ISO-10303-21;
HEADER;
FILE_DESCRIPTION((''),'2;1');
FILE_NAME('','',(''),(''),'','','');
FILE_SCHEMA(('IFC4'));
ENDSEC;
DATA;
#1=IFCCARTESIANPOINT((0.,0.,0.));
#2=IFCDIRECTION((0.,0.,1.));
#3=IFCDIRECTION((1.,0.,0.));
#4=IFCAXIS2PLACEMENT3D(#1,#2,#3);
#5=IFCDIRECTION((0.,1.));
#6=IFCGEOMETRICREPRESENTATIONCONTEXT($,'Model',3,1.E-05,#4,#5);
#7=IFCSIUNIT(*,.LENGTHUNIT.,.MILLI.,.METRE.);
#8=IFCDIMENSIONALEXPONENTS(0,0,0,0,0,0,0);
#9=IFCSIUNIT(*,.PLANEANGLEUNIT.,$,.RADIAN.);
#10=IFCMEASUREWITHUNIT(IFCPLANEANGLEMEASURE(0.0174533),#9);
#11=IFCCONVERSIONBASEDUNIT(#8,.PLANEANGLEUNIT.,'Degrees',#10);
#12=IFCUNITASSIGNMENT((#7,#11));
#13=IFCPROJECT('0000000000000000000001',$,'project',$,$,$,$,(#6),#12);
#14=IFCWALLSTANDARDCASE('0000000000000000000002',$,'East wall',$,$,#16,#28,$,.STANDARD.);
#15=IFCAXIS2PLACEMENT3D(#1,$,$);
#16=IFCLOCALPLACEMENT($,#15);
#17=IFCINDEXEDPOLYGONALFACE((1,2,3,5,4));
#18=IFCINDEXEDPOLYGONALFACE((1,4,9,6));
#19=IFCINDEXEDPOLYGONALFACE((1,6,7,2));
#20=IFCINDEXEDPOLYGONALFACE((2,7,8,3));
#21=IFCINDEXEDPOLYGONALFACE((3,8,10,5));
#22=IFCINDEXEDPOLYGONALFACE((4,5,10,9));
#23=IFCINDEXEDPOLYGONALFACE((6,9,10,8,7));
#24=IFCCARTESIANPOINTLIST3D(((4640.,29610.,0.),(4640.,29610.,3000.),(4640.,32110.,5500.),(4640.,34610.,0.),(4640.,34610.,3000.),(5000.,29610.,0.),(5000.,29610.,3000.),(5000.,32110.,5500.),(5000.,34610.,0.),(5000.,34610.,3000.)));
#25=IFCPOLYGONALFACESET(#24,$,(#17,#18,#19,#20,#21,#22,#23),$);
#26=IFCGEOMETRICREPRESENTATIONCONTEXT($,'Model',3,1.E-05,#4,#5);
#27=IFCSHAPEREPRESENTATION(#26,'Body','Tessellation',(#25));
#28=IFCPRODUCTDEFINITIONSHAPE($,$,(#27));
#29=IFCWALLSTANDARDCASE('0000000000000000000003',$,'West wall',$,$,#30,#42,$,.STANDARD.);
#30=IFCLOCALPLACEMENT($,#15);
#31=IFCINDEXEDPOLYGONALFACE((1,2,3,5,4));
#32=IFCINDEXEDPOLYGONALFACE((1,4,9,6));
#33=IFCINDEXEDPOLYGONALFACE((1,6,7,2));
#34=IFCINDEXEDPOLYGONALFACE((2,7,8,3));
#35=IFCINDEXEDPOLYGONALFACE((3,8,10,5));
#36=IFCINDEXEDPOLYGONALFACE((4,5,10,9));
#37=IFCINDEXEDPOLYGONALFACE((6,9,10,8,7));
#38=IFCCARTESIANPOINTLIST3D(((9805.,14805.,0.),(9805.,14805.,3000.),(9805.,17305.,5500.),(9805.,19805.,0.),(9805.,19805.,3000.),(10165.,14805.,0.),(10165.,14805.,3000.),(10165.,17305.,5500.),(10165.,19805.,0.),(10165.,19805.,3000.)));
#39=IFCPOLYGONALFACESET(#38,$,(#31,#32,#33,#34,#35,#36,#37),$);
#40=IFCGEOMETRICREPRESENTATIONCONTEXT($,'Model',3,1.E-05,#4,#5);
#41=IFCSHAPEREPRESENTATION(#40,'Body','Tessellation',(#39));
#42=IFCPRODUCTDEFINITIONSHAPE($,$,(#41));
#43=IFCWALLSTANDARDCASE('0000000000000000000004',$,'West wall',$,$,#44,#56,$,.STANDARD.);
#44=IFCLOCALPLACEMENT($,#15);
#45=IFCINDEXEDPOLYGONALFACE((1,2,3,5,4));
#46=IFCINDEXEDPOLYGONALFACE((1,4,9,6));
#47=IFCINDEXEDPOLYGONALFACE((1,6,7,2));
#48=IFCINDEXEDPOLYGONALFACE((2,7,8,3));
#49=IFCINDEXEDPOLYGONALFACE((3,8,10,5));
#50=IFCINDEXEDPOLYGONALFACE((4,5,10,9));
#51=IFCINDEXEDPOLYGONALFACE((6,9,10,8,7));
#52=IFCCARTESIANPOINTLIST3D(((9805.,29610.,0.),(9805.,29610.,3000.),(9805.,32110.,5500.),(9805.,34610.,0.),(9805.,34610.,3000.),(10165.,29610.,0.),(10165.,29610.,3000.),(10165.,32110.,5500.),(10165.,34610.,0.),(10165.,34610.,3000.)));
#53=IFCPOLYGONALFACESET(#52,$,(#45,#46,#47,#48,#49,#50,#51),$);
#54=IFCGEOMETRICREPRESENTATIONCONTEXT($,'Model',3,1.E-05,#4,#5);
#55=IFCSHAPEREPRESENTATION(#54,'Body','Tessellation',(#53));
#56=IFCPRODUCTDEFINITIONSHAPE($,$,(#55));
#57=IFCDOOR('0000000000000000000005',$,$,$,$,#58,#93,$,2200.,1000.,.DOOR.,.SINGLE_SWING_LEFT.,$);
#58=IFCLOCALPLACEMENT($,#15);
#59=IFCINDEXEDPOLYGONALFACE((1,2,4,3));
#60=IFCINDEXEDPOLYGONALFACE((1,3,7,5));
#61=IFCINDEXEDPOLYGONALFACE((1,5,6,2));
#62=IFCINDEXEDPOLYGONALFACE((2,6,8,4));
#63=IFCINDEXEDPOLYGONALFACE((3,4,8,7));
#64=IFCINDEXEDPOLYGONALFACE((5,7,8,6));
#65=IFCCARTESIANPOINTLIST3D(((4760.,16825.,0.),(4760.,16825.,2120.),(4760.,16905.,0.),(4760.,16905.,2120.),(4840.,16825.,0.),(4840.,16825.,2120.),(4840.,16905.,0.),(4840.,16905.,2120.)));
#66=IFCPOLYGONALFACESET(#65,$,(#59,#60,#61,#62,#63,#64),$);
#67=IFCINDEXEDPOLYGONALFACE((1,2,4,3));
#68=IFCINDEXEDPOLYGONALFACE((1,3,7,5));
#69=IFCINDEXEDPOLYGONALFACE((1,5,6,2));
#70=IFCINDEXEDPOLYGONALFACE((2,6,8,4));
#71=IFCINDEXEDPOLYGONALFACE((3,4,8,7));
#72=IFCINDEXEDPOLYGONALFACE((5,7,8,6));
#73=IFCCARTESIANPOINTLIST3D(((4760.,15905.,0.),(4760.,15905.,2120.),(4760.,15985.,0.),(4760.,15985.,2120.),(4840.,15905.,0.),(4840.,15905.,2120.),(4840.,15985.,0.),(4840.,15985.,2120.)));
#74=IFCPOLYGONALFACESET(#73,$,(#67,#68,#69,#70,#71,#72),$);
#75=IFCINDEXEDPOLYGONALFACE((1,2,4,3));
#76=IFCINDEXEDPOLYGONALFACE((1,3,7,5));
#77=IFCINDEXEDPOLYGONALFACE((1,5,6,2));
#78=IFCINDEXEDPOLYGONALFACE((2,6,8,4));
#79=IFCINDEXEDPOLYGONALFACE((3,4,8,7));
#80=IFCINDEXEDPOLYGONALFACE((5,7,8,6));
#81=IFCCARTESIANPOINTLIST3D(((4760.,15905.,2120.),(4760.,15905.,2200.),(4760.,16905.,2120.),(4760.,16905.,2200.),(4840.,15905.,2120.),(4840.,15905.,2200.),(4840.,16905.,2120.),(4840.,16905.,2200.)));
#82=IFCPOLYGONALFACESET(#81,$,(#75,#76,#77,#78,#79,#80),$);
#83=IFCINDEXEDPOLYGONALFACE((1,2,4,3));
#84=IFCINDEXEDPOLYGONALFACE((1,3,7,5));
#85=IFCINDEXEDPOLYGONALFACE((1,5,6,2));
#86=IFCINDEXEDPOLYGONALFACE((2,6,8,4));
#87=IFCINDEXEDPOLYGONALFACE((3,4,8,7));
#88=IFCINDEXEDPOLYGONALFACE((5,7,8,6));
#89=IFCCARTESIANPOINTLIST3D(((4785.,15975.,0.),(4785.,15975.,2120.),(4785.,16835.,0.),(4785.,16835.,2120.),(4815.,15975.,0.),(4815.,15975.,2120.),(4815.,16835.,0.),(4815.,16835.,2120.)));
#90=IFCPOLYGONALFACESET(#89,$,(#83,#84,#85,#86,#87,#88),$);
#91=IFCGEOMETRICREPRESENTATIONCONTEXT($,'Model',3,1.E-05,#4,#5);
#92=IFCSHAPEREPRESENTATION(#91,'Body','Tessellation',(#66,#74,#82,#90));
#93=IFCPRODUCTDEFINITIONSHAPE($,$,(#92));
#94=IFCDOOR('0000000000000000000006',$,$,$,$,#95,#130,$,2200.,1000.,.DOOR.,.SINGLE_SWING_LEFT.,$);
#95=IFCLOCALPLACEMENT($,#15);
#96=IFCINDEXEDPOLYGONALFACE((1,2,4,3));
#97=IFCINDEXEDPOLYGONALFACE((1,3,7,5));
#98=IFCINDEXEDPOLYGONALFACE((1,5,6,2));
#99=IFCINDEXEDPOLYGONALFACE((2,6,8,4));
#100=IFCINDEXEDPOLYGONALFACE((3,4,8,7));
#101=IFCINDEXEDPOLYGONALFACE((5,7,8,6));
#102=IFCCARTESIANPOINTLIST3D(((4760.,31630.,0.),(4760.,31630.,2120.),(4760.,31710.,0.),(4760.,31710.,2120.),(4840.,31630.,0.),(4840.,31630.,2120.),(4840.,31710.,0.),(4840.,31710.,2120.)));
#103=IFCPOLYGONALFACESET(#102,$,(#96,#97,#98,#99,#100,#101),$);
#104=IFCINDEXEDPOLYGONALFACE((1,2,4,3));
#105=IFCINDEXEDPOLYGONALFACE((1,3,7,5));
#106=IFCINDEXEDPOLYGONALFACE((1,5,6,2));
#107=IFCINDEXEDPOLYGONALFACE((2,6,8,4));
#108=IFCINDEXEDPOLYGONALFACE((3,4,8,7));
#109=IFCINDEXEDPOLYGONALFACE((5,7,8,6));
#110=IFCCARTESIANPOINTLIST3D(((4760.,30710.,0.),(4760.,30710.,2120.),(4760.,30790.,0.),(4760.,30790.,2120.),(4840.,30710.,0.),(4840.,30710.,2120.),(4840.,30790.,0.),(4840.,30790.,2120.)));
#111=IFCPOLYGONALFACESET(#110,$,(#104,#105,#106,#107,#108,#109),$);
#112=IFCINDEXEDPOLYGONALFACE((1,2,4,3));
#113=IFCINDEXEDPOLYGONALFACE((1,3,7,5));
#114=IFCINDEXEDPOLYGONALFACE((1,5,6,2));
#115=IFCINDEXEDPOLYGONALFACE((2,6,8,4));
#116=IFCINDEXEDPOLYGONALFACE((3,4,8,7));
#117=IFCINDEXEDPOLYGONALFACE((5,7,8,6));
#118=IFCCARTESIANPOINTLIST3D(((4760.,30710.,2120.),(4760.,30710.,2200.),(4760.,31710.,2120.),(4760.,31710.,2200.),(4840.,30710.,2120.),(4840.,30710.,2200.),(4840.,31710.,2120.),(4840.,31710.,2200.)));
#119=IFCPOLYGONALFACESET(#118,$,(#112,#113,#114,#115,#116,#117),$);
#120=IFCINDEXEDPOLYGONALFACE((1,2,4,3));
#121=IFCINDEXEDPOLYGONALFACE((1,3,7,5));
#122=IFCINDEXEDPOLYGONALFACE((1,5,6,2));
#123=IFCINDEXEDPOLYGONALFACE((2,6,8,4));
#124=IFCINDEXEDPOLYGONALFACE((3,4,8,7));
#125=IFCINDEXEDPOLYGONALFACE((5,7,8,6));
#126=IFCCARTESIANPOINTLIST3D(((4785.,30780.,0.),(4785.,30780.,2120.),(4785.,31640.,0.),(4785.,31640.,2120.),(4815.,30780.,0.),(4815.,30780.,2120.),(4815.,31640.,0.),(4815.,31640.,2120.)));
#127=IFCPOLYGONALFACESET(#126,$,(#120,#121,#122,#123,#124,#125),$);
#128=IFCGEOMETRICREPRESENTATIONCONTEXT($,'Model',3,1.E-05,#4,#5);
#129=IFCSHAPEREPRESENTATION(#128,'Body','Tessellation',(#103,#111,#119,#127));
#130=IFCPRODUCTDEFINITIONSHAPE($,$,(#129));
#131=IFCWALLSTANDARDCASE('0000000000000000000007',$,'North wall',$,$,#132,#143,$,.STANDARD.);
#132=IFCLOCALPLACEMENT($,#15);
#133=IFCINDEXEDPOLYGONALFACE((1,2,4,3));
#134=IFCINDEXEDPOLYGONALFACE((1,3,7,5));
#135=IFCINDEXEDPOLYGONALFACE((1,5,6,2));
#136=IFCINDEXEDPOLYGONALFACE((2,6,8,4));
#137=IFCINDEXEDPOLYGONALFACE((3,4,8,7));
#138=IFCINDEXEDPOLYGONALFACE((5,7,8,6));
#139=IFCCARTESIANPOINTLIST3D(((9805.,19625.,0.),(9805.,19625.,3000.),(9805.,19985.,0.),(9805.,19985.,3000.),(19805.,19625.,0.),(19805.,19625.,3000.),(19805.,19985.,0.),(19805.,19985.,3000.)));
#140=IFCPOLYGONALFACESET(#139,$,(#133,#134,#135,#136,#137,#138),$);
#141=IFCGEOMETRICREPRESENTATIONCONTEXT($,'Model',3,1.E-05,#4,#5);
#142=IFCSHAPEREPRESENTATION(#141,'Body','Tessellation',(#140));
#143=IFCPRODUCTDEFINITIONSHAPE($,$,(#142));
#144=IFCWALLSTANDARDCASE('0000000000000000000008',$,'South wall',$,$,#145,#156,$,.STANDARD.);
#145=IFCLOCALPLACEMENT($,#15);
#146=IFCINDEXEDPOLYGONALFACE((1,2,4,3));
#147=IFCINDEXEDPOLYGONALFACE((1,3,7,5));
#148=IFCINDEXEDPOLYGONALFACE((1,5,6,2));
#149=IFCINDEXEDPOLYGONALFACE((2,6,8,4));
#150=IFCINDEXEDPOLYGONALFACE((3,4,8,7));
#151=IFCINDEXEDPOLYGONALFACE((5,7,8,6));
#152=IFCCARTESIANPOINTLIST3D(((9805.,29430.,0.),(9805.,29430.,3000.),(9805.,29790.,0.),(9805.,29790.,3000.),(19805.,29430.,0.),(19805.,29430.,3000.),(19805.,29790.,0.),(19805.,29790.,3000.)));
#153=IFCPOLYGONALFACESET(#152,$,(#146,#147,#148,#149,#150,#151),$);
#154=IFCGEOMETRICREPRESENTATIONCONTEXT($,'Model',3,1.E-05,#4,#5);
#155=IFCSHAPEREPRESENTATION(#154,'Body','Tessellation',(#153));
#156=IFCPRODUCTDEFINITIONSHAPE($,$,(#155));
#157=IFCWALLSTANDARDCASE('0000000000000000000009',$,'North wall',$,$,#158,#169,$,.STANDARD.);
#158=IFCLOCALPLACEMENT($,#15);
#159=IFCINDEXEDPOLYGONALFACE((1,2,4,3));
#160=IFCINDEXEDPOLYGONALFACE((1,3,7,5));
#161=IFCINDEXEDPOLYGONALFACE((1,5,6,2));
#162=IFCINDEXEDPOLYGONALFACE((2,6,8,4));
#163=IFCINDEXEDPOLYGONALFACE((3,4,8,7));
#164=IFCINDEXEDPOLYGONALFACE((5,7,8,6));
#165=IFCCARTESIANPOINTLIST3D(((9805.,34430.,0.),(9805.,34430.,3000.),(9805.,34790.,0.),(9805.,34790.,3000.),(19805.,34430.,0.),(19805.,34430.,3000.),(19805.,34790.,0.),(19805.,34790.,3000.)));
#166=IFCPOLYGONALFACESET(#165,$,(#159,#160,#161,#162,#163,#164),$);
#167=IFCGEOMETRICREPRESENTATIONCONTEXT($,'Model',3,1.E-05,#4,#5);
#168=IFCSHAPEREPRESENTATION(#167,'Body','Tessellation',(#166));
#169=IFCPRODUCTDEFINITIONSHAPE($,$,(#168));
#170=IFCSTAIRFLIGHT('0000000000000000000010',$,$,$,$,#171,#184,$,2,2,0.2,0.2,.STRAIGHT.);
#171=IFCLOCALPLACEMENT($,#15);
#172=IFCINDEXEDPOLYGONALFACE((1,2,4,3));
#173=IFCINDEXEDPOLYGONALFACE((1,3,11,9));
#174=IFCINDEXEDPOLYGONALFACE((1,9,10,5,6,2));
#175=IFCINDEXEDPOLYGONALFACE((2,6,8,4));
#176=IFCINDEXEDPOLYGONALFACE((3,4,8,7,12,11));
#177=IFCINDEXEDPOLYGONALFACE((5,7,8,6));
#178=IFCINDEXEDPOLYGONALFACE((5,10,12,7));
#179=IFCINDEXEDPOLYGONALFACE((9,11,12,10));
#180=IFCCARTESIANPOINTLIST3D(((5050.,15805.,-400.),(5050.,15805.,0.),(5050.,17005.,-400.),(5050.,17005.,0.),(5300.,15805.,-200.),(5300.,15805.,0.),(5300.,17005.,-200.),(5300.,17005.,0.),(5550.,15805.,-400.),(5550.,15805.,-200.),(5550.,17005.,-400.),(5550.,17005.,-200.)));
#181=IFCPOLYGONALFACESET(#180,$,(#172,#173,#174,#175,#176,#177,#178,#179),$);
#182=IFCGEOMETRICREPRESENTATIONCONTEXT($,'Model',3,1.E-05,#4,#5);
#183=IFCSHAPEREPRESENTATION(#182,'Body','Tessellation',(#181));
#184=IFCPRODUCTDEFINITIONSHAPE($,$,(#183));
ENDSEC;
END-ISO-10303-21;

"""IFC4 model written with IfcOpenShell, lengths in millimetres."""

from ifc_helpers import new_model, entity, si_unit, converted_unit, direction, frame, origin_with_axes, place, context, project, polyline, outline, extrude, clip, halfspace, source, transform, mapped, element, save


model = new_model("IFC4")

# Units and contexts
model_context_1 = context("Model", 3, precision=1e-05, world=origin_with_axes(), true_north=direction((0.0, 1.0)))
model_context_2 = context("Model", 3, precision=1e-05, world=origin_with_axes(), true_north=direction((0.0, 1.0)))
model_context_3 = context("Model", 3, precision=1e-05, world=origin_with_axes(), true_north=direction((0.0, 1.0)))
model_context_4 = context("Model", 3, precision=1e-05, world=origin_with_axes(), true_north=direction((0.0, 1.0)))
model_context_5 = context("Model", 3, precision=1e-05, world=origin_with_axes(), true_north=direction((0.0, 1.0)))
model_context_6 = context("Model", 3, precision=1e-05, world=origin_with_axes(), true_north=direction((0.0, 1.0)))
model_context_7 = context("Model", 3, precision=1e-05, world=origin_with_axes(), true_north=direction((0.0, 1.0)))
model_context_8 = context("Model", 3, precision=1e-05, world=origin_with_axes(), true_north=direction((0.0, 1.0)))
model_context_9 = context("Model", 3, precision=1e-05, world=origin_with_axes(), true_north=direction((0.0, 1.0)))
model_context_10 = context("Model", 3, precision=1e-05, world=origin_with_axes(), true_north=direction((0.0, 1.0)))
ifc_project = project(units=[si_unit("LENGTHUNIT", "METRE", prefix="MILLI"), converted_unit("PLANEANGLEUNIT", "Degrees", entity("IfcPlaneAngleMeasure", 0.0174533), si_unit("PLANEANGLEUNIT", "RADIAN"), dimensions=[0, 0, 0, 0, 0, 0, 0])], contexts=[model_context_1])

# Shared definitions
placement_1 = place(None, frame((14805.0, 14805.0, 0.0)))
placement_2 = place(None, frame((14805.0, 29610.0, 0.0)))

# Shared definitions
placement_3 = place(None, frame((0.0, 29610.0, 0.0)))

# Walls
placement_4 = place(None, frame((0.0, 14805.0, 0.0)))
shared_shape_1 = source(origin_with_axes(), model_context_5, "Body", "Clipping", [
    clip(clip(extrude(outline(polyline([(-2500.0, -180.0), (2500.0, -180.0), (2500.0, 180.0), (-2500.0, 180.0), (-2500.0, -180.0), (-2500.0, -180.0)])), origin_with_axes(), (0.0, 0.0, 1.0), 6000.0), halfspace(frame((-2500.0, 0.0, 3000.0), z_axis=(-1.0, 0.0, 1.0), x_axis=(1.0, 0.0, 0.0)), False)), halfspace(frame((2500.0, 0.0, 3000.0), z_axis=(1.0, 0.0, 1.0), x_axis=(1.0, 0.0, 0.0)), False)),
])
wall_1_placement = place(placement_3, frame((4820.0, 2500.0, 0.0), z_axis=(0.0, 0.0, 1.0), x_axis=(0.0, 1.0, 0.0)))
element("IfcWallStandardCase", 1, at=wall_1_placement, Name="East wall", PredefinedType="STANDARD", context=model_context_5, shape_type="MappedRepresentation", body=[
    mapped(shared_shape_1, transform((0.0, 0.0, 0.0))),
])
shared_shape_2 = source(origin_with_axes(), model_context_7, "Body", "Clipping", [
    clip(clip(extrude(outline(polyline([(-2500.0, -180.0), (2500.0, -180.0), (2500.0, 180.0), (-2500.0, 180.0), (-2500.0, -180.0), (-2500.0, -180.0)])), origin_with_axes(), (0.0, 0.0, 1.0), 6000.0), halfspace(frame((-2500.0, 0.0, 3000.0), z_axis=(-1.0, 0.0, 1.0), x_axis=(1.0, 0.0, 0.0)), False)), halfspace(frame((2500.0, 0.0, 3000.0), z_axis=(1.0, 0.0, 1.0), x_axis=(1.0, 0.0, 0.0)), False)),
])
wall_2_placement = place(placement_1, frame((-4820.0, 2500.0, 0.0), z_axis=(0.0, 0.0, 1.0), x_axis=(0.0, -1.0, 0.0)))
element("IfcWallStandardCase", 2, at=wall_2_placement, Name="West wall", PredefinedType="STANDARD", context=model_context_7, shape_type="MappedRepresentation", body=[
    mapped(shared_shape_2, transform((0.0, 0.0, 0.0))),
])
shared_shape_3 = source(origin_with_axes(), model_context_10, "Body", "Clipping", [
    clip(clip(extrude(outline(polyline([(-2500.0, -180.0), (2500.0, -180.0), (2500.0, 180.0), (-2500.0, 180.0), (-2500.0, -180.0), (-2500.0, -180.0)])), origin_with_axes(), (0.0, 0.0, 1.0), 6000.0), halfspace(frame((-2500.0, 0.0, 3000.0), z_axis=(-1.0, 0.0, 1.0), x_axis=(1.0, 0.0, 0.0)), False)), halfspace(frame((2500.0, 0.0, 3000.0), z_axis=(1.0, 0.0, 1.0), x_axis=(1.0, 0.0, 0.0)), False)),
])
wall_3_placement = place(placement_2, frame((-4820.0, 2500.0, 0.0), z_axis=(0.0, 0.0, 1.0), x_axis=(0.0, -1.0, 0.0)))
element("IfcWallStandardCase", 3, at=wall_3_placement, Name="West wall", PredefinedType="STANDARD", context=model_context_10, shape_type="MappedRepresentation", body=[
    mapped(shared_shape_3, transform((0.0, 0.0, 0.0))),
])

# Doors
door_1_placement = place(placement_4, frame((4800.0, 1600.0, 0.0), z_axis=(0.0, 0.0, 1.0), x_axis=(0.0, 1.0, 0.0)))
element("IfcDoor", 4, at=door_1_placement, OperationType="SINGLE_SWING_LEFT", OverallHeight=2200.0, OverallWidth=1000.0, PredefinedType="DOOR", context=model_context_2, shape_type="SweptSolid", body=[
    extrude(outline(polyline([(-40.0, -40.0), (40.0, -40.0), (40.0, 40.0), (-40.0, 40.0), (-40.0, -40.0), (-40.0, -40.0)])), frame((460.0, 0.0, 0.0), z_axis=(0.0, 0.0, 1.0), x_axis=(1.0, 0.0, 0.0)), (0.0, 0.0, 1.0), 2120.0),
    extrude(outline(polyline([(-40.0, -40.0), (40.0, -40.0), (40.0, 40.0), (-40.0, 40.0), (-40.0, -40.0), (-40.0, -40.0)])), frame((-460.0, 0.0, 0.0), z_axis=(0.0, 0.0, 1.0), x_axis=(1.0, 0.0, 0.0)), (0.0, 0.0, 1.0), 2120.0),
    extrude(outline(polyline([(-500.0, -40.0), (500.0, -40.0), (500.0, 40.0), (-500.0, 40.0), (-500.0, -40.0), (-500.0, -40.0)])), frame((0.0, 0.0, 2120.0), z_axis=(0.0, 0.0, 1.0), x_axis=(1.0, 0.0, 0.0)), (0.0, 0.0, 1.0), 80.0),
    extrude(outline(polyline([(-430.0, -15.0), (430.0, -15.0), (430.0, 15.0), (-430.0, 15.0), (-430.0, -15.0), (-430.0, -15.0)])), origin_with_axes(), (0.0, 0.0, 1.0), 2120.0),
])
door_2_placement = place(placement_3, frame((4800.0, 1600.0, 0.0), z_axis=(0.0, 0.0, 1.0), x_axis=(0.0, 1.0, 0.0)))
element("IfcDoor", 5, at=door_2_placement, OperationType="SINGLE_SWING_LEFT", OverallHeight=2200.0, OverallWidth=1000.0, PredefinedType="DOOR", context=model_context_4, shape_type="SweptSolid", body=[
    extrude(outline(polyline([(-40.0, -40.0), (40.0, -40.0), (40.0, 40.0), (-40.0, 40.0), (-40.0, -40.0), (-40.0, -40.0)])), frame((460.0, 0.0, 0.0), z_axis=(0.0, 0.0, 1.0), x_axis=(1.0, 0.0, 0.0)), (0.0, 0.0, 1.0), 2120.0),
    extrude(outline(polyline([(-40.0, -40.0), (40.0, -40.0), (40.0, 40.0), (-40.0, 40.0), (-40.0, -40.0), (-40.0, -40.0)])), frame((-460.0, 0.0, 0.0), z_axis=(0.0, 0.0, 1.0), x_axis=(1.0, 0.0, 0.0)), (0.0, 0.0, 1.0), 2120.0),
    extrude(outline(polyline([(-500.0, -40.0), (500.0, -40.0), (500.0, 40.0), (-500.0, 40.0), (-500.0, -40.0), (-500.0, -40.0)])), frame((0.0, 0.0, 2120.0), z_axis=(0.0, 0.0, 1.0), x_axis=(1.0, 0.0, 0.0)), (0.0, 0.0, 1.0), 80.0),
    extrude(outline(polyline([(-430.0, -15.0), (430.0, -15.0), (430.0, 15.0), (-430.0, 15.0), (-430.0, -15.0), (-430.0, -15.0)])), origin_with_axes(), (0.0, 0.0, 1.0), 2120.0),
])

# Walls
wall_4_placement = place(placement_1, frame((0.0, 5000.0, 0.0), z_axis=(0.0, 0.0, 1.0), x_axis=(1.0, 0.0, 0.0)))
element("IfcWallStandardCase", 6, at=wall_4_placement, Name="North wall", PredefinedType="STANDARD", context=model_context_6, shape_type="SweptSolid", body=[
    extrude(outline(polyline([(-5000.0, -180.0), (5000.0, -180.0), (5000.0, 180.0), (-5000.0, 180.0), (-5000.0, -180.0), (-5000.0, -180.0)])), origin_with_axes(), (0.0, 0.0, 1.0), 3000.0),
])
wall_5_placement = place(placement_2, origin_with_axes())
element("IfcWallStandardCase", 7, at=wall_5_placement, Name="South wall", PredefinedType="STANDARD", context=model_context_8, shape_type="SweptSolid", body=[
    extrude(outline(polyline([(-5000.0, -180.0), (5000.0, -180.0), (5000.0, 180.0), (-5000.0, 180.0), (-5000.0, -180.0), (-5000.0, -180.0)])), origin_with_axes(), (0.0, 0.0, 1.0), 3000.0),
])
wall_6_placement = place(placement_2, frame((0.0, 5000.0, 0.0), z_axis=(0.0, 0.0, 1.0), x_axis=(1.0, 0.0, 0.0)))
element("IfcWallStandardCase", 8, at=wall_6_placement, Name="North wall", PredefinedType="STANDARD", context=model_context_9, shape_type="SweptSolid", body=[
    extrude(outline(polyline([(-5000.0, -180.0), (5000.0, -180.0), (5000.0, 180.0), (-5000.0, 180.0), (-5000.0, -180.0), (-5000.0, -180.0)])), origin_with_axes(), (0.0, 0.0, 1.0), 3000.0),
])

# Stair flight
stair_flight_1_placement = place(placement_4, frame((5050.0, 1000.0, 0.0), z_axis=(0.0, 1.0, 0.0), x_axis=(1.0, 0.0, 0.0)))
element("IfcStairFlight", 9, at=stair_flight_1_placement, NumberOfRisers=2, NumberOfTreads=2, PredefinedType="STRAIGHT", RiserHeight=0.2, TreadLength=0.2, context=model_context_3, shape_type="SweptSolid", body=[
    extrude(outline(polyline([(0.0, 0.0), (250.0, 0.0), (250.0, 200.0), (500.0, 200.0), (500.0, 400.0), (0.0, 400.0), (0.0, 0.0)])), origin_with_axes(), (0.0, 0.0, 1.0), 1200.0),
])

save(model, "model.ifc")
